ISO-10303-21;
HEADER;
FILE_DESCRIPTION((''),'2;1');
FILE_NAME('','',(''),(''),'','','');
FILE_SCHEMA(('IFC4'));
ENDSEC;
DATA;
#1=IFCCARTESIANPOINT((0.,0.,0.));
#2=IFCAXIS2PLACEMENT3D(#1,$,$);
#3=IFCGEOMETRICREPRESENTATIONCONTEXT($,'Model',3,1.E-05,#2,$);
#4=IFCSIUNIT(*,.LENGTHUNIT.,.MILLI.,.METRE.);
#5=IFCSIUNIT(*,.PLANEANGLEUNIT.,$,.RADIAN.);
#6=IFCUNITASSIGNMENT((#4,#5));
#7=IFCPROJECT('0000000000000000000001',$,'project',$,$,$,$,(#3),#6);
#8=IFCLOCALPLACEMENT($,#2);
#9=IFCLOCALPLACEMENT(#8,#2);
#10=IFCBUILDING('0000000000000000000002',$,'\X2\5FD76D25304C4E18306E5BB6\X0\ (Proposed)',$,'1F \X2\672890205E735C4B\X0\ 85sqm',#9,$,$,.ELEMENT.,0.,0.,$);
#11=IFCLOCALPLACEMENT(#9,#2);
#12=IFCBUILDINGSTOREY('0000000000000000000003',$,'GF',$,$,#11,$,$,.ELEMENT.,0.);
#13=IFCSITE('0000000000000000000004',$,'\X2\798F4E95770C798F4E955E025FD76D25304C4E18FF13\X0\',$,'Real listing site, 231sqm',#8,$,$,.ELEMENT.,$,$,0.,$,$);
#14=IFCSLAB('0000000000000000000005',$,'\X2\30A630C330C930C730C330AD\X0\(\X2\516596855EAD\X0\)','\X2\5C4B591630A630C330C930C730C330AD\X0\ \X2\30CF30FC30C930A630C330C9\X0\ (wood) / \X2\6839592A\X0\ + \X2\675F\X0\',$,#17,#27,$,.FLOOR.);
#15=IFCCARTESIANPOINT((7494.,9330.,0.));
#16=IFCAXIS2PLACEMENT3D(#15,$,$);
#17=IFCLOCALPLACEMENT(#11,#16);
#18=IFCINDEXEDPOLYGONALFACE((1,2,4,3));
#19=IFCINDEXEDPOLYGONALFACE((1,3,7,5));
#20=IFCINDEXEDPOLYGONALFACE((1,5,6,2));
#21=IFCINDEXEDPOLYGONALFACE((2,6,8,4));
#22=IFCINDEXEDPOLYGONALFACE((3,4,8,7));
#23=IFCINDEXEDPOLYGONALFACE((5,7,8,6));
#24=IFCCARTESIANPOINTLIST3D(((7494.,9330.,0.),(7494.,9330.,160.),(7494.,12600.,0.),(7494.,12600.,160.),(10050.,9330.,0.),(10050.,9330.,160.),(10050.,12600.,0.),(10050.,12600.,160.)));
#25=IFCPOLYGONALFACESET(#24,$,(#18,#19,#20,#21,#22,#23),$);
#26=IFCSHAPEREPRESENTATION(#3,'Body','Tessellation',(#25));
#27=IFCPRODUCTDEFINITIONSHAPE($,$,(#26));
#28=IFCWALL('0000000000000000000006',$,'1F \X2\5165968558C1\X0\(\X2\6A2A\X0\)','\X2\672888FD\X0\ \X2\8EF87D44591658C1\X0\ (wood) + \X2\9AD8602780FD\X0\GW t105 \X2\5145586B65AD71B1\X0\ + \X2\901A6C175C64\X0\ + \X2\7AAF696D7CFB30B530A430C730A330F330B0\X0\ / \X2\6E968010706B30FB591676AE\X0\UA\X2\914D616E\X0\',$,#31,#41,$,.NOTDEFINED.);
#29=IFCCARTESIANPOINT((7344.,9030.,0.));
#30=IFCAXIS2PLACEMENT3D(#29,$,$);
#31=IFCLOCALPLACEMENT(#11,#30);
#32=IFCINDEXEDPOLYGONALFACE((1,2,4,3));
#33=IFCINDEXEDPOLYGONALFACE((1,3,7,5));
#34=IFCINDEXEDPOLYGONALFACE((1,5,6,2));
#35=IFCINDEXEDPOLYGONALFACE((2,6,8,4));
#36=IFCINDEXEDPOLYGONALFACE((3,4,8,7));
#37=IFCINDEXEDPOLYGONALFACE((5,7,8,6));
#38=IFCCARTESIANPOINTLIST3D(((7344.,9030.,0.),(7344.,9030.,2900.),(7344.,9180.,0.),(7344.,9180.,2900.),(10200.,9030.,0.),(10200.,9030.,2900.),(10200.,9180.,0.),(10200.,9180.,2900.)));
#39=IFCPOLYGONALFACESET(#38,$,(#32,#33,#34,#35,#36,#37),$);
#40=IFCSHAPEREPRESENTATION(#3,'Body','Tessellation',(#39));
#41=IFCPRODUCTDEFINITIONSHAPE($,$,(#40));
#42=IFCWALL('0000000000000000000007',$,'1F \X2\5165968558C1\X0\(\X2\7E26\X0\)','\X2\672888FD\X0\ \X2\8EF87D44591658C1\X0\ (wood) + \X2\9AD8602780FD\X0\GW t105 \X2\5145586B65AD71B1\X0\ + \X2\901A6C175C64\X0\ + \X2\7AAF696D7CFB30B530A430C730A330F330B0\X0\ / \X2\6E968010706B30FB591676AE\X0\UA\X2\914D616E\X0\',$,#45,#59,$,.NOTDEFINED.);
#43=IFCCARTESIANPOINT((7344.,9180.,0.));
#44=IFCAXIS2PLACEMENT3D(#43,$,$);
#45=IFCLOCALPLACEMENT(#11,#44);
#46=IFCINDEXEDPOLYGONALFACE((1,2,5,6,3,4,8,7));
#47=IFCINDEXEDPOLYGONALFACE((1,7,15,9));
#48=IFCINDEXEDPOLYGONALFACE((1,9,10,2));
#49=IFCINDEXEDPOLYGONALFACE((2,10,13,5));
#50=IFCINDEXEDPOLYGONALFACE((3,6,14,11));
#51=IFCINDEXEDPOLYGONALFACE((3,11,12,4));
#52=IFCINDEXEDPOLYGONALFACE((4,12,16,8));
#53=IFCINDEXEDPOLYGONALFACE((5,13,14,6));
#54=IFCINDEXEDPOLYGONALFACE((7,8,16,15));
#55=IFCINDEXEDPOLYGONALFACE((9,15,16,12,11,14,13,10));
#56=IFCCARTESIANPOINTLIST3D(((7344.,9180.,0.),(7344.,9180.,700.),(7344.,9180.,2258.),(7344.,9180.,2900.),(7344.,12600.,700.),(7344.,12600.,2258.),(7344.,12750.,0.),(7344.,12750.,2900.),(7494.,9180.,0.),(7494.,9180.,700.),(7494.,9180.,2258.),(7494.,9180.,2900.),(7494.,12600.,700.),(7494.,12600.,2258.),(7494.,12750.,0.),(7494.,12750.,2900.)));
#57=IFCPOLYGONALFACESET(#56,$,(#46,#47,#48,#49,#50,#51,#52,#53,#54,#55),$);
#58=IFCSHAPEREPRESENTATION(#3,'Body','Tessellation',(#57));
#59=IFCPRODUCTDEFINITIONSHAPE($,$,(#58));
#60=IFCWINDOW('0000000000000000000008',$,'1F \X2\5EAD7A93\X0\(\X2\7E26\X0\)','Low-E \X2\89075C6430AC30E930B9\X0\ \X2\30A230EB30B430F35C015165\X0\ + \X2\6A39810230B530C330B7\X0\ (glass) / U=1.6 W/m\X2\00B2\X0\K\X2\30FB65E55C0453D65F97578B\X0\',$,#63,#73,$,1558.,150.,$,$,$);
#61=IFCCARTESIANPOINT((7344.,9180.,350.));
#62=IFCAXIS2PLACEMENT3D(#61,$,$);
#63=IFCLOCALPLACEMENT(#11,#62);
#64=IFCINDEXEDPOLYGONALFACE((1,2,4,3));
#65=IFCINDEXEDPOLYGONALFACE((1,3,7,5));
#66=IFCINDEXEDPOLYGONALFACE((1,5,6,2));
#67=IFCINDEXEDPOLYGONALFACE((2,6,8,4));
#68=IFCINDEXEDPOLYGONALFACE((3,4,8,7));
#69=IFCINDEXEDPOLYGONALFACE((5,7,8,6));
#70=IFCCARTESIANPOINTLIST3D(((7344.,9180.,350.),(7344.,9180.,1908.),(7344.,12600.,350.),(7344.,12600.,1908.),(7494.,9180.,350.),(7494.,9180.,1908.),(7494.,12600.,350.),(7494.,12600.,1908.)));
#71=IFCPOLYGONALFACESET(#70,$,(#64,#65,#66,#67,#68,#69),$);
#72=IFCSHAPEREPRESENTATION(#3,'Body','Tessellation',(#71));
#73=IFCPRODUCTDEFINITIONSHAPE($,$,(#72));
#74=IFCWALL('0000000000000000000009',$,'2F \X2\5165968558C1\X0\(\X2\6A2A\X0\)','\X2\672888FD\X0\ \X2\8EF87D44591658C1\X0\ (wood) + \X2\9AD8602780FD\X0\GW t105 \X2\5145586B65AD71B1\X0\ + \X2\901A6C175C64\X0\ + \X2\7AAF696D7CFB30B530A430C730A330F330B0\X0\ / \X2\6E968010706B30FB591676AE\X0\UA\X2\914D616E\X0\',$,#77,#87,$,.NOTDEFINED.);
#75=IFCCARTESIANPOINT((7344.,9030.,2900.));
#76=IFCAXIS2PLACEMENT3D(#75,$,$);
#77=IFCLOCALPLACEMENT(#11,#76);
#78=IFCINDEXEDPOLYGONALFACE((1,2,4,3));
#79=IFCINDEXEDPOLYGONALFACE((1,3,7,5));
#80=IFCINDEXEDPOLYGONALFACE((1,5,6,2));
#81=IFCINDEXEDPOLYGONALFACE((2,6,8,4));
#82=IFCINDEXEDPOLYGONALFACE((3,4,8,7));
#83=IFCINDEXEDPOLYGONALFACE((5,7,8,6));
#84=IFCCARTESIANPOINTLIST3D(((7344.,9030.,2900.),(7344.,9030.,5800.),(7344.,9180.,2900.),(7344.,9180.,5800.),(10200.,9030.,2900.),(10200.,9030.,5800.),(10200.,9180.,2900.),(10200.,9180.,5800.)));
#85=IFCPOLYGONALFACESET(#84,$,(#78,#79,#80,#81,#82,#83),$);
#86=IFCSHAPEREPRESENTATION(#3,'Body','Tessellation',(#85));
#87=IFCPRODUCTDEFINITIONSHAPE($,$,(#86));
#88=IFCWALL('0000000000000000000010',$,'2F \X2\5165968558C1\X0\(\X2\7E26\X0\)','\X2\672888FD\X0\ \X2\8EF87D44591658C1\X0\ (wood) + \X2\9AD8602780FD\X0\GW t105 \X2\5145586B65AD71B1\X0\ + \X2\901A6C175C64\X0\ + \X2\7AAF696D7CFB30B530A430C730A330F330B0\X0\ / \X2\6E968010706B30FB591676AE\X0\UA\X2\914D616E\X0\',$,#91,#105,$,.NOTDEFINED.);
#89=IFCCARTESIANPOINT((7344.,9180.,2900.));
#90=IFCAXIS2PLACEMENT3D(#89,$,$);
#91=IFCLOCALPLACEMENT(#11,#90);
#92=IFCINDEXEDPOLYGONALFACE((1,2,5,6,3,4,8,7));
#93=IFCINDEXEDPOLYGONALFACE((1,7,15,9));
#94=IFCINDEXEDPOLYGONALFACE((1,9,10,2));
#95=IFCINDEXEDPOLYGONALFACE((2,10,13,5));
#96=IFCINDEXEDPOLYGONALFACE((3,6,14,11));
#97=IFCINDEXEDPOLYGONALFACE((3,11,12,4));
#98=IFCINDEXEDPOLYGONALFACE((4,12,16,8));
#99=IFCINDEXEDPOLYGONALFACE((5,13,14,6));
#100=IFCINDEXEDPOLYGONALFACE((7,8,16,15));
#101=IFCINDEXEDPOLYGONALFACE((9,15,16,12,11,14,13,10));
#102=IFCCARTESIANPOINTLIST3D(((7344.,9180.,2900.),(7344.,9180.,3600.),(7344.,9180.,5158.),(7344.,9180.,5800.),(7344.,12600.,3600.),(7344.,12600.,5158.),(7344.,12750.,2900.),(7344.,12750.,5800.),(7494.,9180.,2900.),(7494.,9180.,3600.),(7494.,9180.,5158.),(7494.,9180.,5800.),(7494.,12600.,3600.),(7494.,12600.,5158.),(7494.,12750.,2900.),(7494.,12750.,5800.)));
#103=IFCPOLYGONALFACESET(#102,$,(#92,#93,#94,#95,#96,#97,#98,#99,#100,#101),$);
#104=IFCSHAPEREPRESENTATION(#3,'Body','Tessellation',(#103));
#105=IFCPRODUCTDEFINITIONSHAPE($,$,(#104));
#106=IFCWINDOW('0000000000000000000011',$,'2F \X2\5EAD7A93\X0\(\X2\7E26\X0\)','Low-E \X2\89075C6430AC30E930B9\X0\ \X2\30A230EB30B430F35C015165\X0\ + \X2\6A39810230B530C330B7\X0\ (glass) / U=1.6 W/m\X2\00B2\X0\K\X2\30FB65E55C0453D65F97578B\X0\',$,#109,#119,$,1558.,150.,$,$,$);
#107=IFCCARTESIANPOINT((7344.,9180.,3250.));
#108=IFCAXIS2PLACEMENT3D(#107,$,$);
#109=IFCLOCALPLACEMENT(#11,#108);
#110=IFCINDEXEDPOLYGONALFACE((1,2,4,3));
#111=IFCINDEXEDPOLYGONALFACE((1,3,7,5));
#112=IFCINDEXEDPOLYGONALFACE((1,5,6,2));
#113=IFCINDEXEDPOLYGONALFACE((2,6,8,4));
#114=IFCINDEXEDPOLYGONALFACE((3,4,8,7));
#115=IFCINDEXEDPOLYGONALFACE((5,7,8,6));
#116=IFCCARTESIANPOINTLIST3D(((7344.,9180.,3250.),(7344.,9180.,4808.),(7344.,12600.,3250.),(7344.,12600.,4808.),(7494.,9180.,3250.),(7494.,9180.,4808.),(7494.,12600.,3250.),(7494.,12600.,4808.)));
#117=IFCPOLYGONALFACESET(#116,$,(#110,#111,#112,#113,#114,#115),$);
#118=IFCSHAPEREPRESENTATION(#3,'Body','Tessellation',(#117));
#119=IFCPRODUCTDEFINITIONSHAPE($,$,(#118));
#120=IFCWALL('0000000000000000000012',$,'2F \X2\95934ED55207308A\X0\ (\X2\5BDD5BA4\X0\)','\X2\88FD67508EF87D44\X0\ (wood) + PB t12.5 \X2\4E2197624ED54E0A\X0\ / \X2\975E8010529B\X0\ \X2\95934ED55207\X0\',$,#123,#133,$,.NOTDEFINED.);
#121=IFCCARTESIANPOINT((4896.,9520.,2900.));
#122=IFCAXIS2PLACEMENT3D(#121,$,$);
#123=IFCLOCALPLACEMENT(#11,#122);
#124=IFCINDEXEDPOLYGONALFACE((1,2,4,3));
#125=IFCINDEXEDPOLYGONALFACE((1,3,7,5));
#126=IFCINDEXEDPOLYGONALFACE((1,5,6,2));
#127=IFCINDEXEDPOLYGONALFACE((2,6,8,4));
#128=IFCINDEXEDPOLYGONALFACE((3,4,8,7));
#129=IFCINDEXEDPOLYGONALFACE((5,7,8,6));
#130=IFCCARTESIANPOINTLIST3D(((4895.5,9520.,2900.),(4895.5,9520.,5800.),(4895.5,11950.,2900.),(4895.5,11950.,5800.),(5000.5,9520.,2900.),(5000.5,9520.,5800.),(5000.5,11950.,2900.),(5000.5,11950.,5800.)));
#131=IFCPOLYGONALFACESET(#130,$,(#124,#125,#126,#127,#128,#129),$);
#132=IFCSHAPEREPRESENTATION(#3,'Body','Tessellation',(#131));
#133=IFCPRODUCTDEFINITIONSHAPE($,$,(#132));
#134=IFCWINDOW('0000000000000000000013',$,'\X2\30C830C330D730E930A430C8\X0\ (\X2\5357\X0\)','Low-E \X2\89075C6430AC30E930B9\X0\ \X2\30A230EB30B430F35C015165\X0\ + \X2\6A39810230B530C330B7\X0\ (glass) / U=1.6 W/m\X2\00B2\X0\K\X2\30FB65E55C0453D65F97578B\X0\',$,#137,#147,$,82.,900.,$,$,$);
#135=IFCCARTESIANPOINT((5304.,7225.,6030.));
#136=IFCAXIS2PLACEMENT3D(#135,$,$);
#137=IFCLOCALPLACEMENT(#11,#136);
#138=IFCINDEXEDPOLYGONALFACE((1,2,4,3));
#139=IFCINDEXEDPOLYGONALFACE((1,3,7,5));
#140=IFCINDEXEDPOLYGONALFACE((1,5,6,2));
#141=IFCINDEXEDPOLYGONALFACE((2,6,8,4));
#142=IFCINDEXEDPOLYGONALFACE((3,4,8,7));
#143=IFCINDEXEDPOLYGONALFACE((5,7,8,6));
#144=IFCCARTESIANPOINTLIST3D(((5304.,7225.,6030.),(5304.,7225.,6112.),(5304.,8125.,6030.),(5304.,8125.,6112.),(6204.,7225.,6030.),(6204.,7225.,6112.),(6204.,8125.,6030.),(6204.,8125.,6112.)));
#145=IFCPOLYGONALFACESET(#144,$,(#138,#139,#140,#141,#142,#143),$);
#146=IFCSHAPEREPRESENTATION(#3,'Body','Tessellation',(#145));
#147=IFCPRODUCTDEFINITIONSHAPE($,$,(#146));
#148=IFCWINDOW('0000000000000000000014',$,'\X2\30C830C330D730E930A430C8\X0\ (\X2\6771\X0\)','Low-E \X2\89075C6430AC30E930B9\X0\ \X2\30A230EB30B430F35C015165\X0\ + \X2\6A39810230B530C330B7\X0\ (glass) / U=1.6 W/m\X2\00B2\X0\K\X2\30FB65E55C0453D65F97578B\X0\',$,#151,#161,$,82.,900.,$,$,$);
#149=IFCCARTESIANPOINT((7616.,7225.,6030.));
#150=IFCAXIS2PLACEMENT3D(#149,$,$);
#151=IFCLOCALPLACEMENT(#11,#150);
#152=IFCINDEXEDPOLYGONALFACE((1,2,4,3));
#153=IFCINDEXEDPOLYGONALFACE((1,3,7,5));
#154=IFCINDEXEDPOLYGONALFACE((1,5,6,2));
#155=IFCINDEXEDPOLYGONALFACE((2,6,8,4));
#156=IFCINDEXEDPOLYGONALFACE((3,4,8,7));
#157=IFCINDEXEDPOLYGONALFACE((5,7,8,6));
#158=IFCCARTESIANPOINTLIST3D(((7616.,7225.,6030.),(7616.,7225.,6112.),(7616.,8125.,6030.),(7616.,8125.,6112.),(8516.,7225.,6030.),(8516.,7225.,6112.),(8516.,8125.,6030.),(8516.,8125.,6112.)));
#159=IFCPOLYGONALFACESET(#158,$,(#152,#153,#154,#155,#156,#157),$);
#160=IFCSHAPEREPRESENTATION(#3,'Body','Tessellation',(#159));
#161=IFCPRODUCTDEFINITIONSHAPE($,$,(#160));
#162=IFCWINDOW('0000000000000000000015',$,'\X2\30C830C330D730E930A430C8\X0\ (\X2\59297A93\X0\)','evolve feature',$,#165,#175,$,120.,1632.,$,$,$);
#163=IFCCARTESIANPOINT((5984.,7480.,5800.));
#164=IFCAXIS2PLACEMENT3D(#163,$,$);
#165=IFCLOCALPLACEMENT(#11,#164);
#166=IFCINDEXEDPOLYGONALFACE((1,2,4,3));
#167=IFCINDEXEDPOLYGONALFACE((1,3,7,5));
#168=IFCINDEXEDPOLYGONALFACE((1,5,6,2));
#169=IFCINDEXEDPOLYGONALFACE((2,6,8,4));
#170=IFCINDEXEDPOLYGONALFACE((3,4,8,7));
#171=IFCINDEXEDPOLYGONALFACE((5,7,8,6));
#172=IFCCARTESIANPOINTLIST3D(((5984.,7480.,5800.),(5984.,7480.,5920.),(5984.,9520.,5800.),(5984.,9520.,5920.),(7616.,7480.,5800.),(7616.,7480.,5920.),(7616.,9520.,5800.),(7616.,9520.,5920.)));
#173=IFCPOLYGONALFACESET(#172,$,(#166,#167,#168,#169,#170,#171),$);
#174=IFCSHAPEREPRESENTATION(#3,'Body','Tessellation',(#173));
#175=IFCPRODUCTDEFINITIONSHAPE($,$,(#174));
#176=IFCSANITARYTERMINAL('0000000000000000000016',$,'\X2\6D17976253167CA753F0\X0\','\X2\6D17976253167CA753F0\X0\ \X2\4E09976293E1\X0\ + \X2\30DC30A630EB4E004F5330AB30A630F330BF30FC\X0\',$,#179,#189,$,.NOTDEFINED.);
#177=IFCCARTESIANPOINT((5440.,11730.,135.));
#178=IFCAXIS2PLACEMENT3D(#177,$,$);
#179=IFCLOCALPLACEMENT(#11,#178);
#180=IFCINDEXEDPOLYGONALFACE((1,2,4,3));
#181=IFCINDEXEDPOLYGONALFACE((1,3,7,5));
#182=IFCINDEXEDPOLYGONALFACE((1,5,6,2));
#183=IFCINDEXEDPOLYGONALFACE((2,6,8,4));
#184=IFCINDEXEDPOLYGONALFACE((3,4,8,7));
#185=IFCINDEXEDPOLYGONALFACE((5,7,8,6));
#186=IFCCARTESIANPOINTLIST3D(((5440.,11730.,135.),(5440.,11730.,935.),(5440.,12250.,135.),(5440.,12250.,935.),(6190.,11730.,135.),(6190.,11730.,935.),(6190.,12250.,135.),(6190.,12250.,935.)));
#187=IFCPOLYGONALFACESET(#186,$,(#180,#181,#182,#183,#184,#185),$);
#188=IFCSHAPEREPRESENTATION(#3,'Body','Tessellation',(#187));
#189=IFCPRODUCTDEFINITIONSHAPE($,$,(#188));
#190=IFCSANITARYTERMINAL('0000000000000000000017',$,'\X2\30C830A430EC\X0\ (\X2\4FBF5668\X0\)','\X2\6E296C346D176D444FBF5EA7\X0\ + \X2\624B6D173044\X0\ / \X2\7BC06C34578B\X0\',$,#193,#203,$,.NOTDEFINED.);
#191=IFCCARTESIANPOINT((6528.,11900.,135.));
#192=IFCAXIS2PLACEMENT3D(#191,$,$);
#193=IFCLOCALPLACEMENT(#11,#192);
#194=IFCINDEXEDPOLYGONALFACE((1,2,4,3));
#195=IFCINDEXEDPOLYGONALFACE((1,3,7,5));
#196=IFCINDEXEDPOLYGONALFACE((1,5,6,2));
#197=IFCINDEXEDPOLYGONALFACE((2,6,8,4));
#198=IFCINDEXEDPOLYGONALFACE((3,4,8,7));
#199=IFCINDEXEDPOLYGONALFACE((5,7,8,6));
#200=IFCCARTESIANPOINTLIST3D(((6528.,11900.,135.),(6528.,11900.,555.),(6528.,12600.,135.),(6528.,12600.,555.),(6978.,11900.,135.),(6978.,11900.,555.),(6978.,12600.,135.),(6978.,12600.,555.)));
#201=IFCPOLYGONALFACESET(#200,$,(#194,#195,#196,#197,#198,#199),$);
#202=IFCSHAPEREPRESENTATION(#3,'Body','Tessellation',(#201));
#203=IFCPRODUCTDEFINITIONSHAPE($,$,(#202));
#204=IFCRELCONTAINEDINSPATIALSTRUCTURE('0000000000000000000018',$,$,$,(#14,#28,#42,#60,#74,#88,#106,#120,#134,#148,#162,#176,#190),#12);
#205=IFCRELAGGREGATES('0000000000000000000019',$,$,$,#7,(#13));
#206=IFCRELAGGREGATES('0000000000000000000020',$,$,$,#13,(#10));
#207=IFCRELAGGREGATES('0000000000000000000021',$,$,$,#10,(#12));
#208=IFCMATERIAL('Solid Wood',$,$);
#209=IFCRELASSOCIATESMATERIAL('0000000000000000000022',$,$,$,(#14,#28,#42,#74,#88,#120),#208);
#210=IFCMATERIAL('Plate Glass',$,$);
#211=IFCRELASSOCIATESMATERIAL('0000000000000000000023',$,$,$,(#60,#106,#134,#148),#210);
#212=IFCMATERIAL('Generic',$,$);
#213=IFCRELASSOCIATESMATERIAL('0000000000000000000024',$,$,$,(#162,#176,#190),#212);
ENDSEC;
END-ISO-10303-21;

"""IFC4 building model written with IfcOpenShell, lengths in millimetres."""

from ifc_helpers import new_model, si_unit, frame, frame_2d, origin, place, context, project, spatial, rectangle, extrude, material, element, fill, save


model = new_model("IFC4")

# Units and contexts
model_context = context("Model", 3, precision=1e-05, world=origin())
ifc_project = project(units=[si_unit("LENGTHUNIT", "METRE", prefix="MILLI"), si_unit("PLANEANGLEUNIT", "RADIAN")], contexts=[model_context])

# Site, building, storey
site_placement = place(None, origin())
site = spatial("IfcSite", under=ifc_project, at=site_placement, Name="福井県福井市志津が丘３", ObjectType="Real listing site, 231sqm", CompositionType="ELEMENT", RefElevation=0.0)
building_placement = place(site_placement, origin())
building = spatial("IfcBuilding", under=site, at=building_placement, Name="志津が丘の家 (Proposed)", ObjectType="1F 木造平屋 85sqm", CompositionType="ELEMENT", ElevationOfRefHeight=0.0, ElevationOfTerrain=0.0)
storey_placement = place(building_placement, origin())
storey = spatial("IfcBuildingStorey", under=building, at=storey_placement, Name="GF", CompositionType="ELEMENT", Elevation=0.0)

# Slab
ifc_material_1 = material(Name="Solid Wood")
slab_placement = place(storey_placement, frame((7494.0, 9330.0, 0.0)))
element("IfcSlab", 1, at=slab_placement, inside=storey, material=ifc_material_1, Name="ウッドデッキ(入隅庭)", Description="屋外ウッドデッキ ハードウッド (wood) / 根太 + 束", PredefinedType="FLOOR", context=model_context, shape_type="SweptSolid", body=[
    extrude(rectangle(XDim=2556.0, YDim=3270.0, at=frame_2d((1278.0, 1635.0))), frame((7494.0, 9330.0, 0.0)), (0.0, 0.0, 1.0), 160.0),
])

# Wall
wall_1_placement = place(storey_placement, frame((7344.0, 9030.0, 0.0)))
element("IfcWall", 2, at=wall_1_placement, inside=storey, material=ifc_material_1, Name="1F 入隅壁(横)", Description="木製 軸組外壁 (wood) + 高性能GW t105 充填断熱 + 通気層 + 窯業系サイディング / 準耐火・外皮UA配慮", PredefinedType="NOTDEFINED", context=model_context, shape_type="SweptSolid", body=[
    extrude(rectangle(XDim=2856.0, YDim=150.0, at=frame_2d((1428.0, 75.0))), frame((7344.0, 9030.0, 0.0)), (0.0, 0.0, 1.0), 2900.0),
])

# Wall, opening, window
wall_2_placement = place(storey_placement, frame((7344.0, 9180.0, 0.0)))
wall_2 = element("IfcWall", 3, at=wall_2_placement, inside=storey, material=ifc_material_1, Name="1F 入隅壁(縦)", Description="木製 軸組外壁 (wood) + 高性能GW t105 充填断熱 + 通気層 + 窯業系サイディング / 準耐火・外皮UA配慮", PredefinedType="NOTDEFINED", context=model_context, shape_type="SweptSolid", body=[
    extrude(rectangle(XDim=150.0, YDim=3570.0, at=frame_2d((75.0, 1785.0))), frame((7344.0, 9180.0, 0.0)), (0.0, 0.0, 1.0), 2900.0),
])
opening_1_placement = place(storey_placement, frame((7344.0, 9180.0, 350.0)))
opening_1 = element("IfcOpeningElement", 4, at=opening_1_placement, cuts=wall_2, PredefinedType="NOTDEFINED", context=model_context, shape_type="SweptSolid", body=[
    extrude(rectangle(XDim=150.0, YDim=3420.0, at=frame_2d((75.0, 1710.0))), frame((7344.0, 9180.0, 350.0)), (0.0, 0.0, 1.0), 1558.0),
])
ifc_material_2 = material(Name="Plate Glass")
window_1_placement = place(storey_placement, frame((7344.0, 9180.0, 350.0)))
window_1 = element("IfcWindow", 5, at=window_1_placement, inside=storey, material=ifc_material_2, Name="1F 庭窓(縦)", Description="Low-E 複層ガラス アルゴン封入 + 樹脂サッシ (glass) / U=1.6 W/m²K・日射取得型", OverallHeight=1558.0, OverallWidth=150.0, context=model_context, shape_type="SweptSolid", body=[
    extrude(rectangle(XDim=150.0, YDim=3420.0, at=frame_2d((75.0, 1710.0))), frame((7344.0, 9180.0, 350.0)), (0.0, 0.0, 1.0), 1558.0),
])
fill(opening_1, window_1)

# Wall
wall_3_placement = place(storey_placement, frame((7344.0, 9030.0, 2900.0)))
element("IfcWall", 6, at=wall_3_placement, inside=storey, material=ifc_material_1, Name="2F 入隅壁(横)", Description="木製 軸組外壁 (wood) + 高性能GW t105 充填断熱 + 通気層 + 窯業系サイディング / 準耐火・外皮UA配慮", PredefinedType="NOTDEFINED", context=model_context, shape_type="SweptSolid", body=[
    extrude(rectangle(XDim=2856.0, YDim=150.0, at=frame_2d((1428.0, 75.0))), frame((7344.0, 9030.0, 2900.0)), (0.0, 0.0, 1.0), 2900.0),
])

# Wall, opening, window
wall_4_placement = place(storey_placement, frame((7344.0, 9180.0, 2900.0)))
wall_4 = element("IfcWall", 7, at=wall_4_placement, inside=storey, material=ifc_material_1, Name="2F 入隅壁(縦)", Description="木製 軸組外壁 (wood) + 高性能GW t105 充填断熱 + 通気層 + 窯業系サイディング / 準耐火・外皮UA配慮", PredefinedType="NOTDEFINED", context=model_context, shape_type="SweptSolid", body=[
    extrude(rectangle(XDim=150.0, YDim=3570.0, at=frame_2d((75.0, 1785.0))), frame((7344.0, 9180.0, 2900.0)), (0.0, 0.0, 1.0), 2900.0),
])
opening_2_placement = place(storey_placement, frame((7344.0, 9180.0, 3250.0)))
opening_2 = element("IfcOpeningElement", 8, at=opening_2_placement, cuts=wall_4, PredefinedType="NOTDEFINED", context=model_context, shape_type="SweptSolid", body=[
    extrude(rectangle(XDim=150.0, YDim=3420.0, at=frame_2d((75.0, 1710.0))), frame((7344.0, 9180.0, 3250.0)), (0.0, 0.0, 1.0), 1558.0),
])
window_2_placement = place(storey_placement, frame((7344.0, 9180.0, 3250.0)))
window_2 = element("IfcWindow", 9, at=window_2_placement, inside=storey, material=ifc_material_2, Name="2F 庭窓(縦)", Description="Low-E 複層ガラス アルゴン封入 + 樹脂サッシ (glass) / U=1.6 W/m²K・日射取得型", OverallHeight=1558.0, OverallWidth=150.0, context=model_context, shape_type="SweptSolid", body=[
    extrude(rectangle(XDim=150.0, YDim=3420.0, at=frame_2d((75.0, 1710.0))), frame((7344.0, 9180.0, 3250.0)), (0.0, 0.0, 1.0), 1558.0),
])
fill(opening_2, window_2)

# Wall
wall_5_placement = place(storey_placement, frame((4896.0, 9520.0, 2900.0)))
element("IfcWall", 10, at=wall_5_placement, inside=storey, material=ifc_material_1, Name="2F 間仕切り (寝室)", Description="製材軸組 (wood) + PB t12.5 両面仕上 / 非耐力 間仕切", PredefinedType="NOTDEFINED", context=model_context, shape_type="SweptSolid", body=[
    extrude(rectangle(XDim=105.0, YDim=2430.0, at=frame_2d((52.0, 1215.0))), frame((4896.0, 9520.0, 2900.0)), (0.0, 0.0, 1.0), 2900.0),
])

# Windows
window_3_placement = place(storey_placement, frame((5304.0, 7225.0, 6030.0)))
element("IfcWindow", 11, at=window_3_placement, inside=storey, material=ifc_material_2, Name="トップライト (南)", Description="Low-E 複層ガラス アルゴン封入 + 樹脂サッシ (glass) / U=1.6 W/m²K・日射取得型", OverallHeight=82.0, OverallWidth=900.0, context=model_context, shape_type="SweptSolid", body=[
    extrude(rectangle(XDim=900.0, YDim=900.0, at=frame_2d((450.0, 450.0))), frame((5304.0, 7225.0, 6030.0)), (0.0, 0.0, 1.0), 82.0),
])
window_4_placement = place(storey_placement, frame((7616.0, 7225.0, 6030.0)))
element("IfcWindow", 12, at=window_4_placement, inside=storey, material=ifc_material_2, Name="トップライト (東)", Description="Low-E 複層ガラス アルゴン封入 + 樹脂サッシ (glass) / U=1.6 W/m²K・日射取得型", OverallHeight=82.0, OverallWidth=900.0, context=model_context, shape_type="SweptSolid", body=[
    extrude(rectangle(XDim=900.0, YDim=900.0, at=frame_2d((450.0, 450.0))), frame((7616.0, 7225.0, 6030.0)), (0.0, 0.0, 1.0), 82.0),
])
ifc_material_3 = material(Name="Generic")
window_5_placement = place(storey_placement, frame((5984.0, 7480.0, 5800.0)))
element("IfcWindow", 13, at=window_5_placement, inside=storey, material=ifc_material_3, Name="トップライト (天窓)", Description="evolve feature", OverallHeight=120.0, OverallWidth=1632.0, context=model_context, shape_type="SweptSolid", body=[
    extrude(rectangle(XDim=1632.0, YDim=2040.0, at=frame_2d((816.0, 1020.0))), frame((5984.0, 7480.0, 5800.0)), (0.0, 0.0, 1.0), 120.0),
])

# Sanitary terminals
sanitary_terminal_1_placement = place(storey_placement, frame((5440.0, 11730.0, 135.0)))
element("IfcSanitaryTerminal", 14, at=sanitary_terminal_1_placement, inside=storey, material=ifc_material_3, Name="洗面化粧台", Description="洗面化粧台 三面鏡 + ボウル一体カウンター", PredefinedType="NOTDEFINED", context=model_context, shape_type="SweptSolid", body=[
    extrude(rectangle(XDim=750.0, YDim=520.0, at=frame_2d((375.0, 260.0))), frame((5440.0, 11730.0, 135.0)), (0.0, 0.0, 1.0), 800.0),
])
sanitary_terminal_2_placement = place(storey_placement, frame((6528.0, 11900.0, 135.0)))
element("IfcSanitaryTerminal", 15, at=sanitary_terminal_2_placement, inside=storey, material=ifc_material_3, Name="トイレ (便器)", Description="温水洗浄便座 + 手洗い / 節水型", PredefinedType="NOTDEFINED", context=model_context, shape_type="SweptSolid", body=[
    extrude(rectangle(XDim=450.0, YDim=700.0, at=frame_2d((225.0, 350.0))), frame((6528.0, 11900.0, 135.0)), (0.0, 0.0, 1.0), 420.0),
])

save(model, "model.ifc")
